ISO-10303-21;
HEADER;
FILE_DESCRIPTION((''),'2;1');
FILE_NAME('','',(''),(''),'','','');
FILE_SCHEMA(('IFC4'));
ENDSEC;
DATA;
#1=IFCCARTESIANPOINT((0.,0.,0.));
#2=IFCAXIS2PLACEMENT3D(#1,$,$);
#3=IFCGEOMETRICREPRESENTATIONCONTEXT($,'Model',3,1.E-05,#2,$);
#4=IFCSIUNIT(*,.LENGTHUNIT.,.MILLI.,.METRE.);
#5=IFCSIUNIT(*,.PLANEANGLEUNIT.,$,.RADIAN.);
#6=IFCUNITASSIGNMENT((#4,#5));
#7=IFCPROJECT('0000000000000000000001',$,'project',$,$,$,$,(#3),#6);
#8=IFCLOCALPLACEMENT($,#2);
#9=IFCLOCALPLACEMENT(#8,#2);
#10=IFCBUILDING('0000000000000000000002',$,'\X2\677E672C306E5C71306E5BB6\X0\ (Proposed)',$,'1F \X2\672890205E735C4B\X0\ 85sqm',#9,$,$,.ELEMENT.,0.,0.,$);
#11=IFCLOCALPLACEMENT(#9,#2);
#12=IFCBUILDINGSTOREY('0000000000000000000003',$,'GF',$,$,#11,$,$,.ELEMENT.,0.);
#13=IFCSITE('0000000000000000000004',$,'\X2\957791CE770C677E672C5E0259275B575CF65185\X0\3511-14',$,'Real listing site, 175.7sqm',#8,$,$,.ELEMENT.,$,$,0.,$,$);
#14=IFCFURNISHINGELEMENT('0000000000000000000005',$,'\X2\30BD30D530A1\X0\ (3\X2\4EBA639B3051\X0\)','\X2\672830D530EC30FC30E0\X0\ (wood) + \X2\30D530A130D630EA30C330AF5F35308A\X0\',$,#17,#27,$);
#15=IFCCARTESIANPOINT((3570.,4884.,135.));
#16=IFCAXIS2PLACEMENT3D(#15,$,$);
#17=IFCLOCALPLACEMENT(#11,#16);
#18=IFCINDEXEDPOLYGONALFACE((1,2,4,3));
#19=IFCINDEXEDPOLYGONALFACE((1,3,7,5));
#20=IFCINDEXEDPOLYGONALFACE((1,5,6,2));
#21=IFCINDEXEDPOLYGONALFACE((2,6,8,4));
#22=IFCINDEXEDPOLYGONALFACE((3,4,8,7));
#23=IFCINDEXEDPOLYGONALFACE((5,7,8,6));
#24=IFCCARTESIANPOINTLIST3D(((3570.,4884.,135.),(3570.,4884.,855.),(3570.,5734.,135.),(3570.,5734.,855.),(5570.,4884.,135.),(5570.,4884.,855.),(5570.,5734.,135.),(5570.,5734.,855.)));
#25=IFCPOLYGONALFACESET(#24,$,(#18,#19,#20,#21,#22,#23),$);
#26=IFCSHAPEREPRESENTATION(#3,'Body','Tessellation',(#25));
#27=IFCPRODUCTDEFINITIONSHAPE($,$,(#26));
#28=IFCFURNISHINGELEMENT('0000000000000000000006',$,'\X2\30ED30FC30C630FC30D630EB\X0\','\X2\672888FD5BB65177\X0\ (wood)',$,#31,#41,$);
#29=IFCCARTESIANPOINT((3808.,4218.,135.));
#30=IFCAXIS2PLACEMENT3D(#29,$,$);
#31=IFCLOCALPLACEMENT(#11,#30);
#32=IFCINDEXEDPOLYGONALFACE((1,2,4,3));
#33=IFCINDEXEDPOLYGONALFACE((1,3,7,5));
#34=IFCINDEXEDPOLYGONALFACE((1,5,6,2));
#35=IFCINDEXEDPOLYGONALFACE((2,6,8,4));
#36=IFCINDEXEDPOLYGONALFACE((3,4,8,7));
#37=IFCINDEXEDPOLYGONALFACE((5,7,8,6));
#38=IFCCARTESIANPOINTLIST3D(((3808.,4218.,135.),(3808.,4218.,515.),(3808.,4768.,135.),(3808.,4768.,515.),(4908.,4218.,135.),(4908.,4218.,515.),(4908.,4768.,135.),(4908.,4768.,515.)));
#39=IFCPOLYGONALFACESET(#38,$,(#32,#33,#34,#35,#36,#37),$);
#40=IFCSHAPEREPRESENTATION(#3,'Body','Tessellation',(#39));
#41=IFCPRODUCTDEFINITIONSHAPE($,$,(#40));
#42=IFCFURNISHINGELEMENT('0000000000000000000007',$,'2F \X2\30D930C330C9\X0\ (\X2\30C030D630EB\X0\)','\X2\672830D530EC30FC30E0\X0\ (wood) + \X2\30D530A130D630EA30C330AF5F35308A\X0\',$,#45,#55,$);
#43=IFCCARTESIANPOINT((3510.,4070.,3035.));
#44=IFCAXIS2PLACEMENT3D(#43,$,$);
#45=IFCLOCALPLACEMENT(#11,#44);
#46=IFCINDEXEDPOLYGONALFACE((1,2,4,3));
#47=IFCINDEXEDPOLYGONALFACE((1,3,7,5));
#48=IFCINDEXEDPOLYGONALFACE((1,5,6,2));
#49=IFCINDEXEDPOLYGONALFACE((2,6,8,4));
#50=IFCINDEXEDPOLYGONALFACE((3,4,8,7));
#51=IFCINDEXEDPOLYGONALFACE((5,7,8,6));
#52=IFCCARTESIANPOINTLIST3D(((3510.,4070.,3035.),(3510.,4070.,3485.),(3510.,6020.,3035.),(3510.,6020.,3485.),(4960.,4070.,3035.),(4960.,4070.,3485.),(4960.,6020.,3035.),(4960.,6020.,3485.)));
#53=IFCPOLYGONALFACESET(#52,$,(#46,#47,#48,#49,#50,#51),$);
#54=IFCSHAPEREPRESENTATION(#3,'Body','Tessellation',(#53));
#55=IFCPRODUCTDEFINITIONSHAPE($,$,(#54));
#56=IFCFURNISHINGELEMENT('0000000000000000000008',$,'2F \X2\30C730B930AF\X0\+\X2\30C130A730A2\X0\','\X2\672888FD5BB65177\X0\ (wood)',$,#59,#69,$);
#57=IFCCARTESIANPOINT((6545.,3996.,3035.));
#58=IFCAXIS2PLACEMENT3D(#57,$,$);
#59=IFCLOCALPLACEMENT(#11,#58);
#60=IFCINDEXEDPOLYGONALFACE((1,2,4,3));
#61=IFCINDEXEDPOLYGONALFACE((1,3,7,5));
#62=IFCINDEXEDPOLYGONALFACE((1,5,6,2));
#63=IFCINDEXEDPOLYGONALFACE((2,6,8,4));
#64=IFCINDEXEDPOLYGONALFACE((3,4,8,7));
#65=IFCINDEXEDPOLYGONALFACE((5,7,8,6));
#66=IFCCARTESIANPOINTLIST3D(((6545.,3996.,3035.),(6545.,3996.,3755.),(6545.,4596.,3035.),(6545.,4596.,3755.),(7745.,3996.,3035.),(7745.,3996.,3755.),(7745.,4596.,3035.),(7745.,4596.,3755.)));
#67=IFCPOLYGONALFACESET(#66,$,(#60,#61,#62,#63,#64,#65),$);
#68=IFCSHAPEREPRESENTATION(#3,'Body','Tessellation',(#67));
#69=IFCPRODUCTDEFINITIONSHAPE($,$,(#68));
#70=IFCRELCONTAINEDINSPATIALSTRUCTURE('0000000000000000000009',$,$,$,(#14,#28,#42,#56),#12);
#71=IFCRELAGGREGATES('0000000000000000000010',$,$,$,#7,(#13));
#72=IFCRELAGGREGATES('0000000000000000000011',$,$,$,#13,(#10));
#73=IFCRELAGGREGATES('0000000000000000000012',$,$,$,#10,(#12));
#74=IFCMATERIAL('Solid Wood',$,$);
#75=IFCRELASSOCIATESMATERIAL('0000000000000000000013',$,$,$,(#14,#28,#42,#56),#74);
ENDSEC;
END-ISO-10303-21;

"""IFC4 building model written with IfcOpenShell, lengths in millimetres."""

from ifc_helpers import new_model, si_unit, frame, frame_2d, origin, place, context, project, spatial, rectangle, extrude, material, element, save


model = new_model("IFC4")

# Units and contexts
model_context = context("Model", 3, precision=1e-05, world=origin())
ifc_project = project(units=[si_unit("LENGTHUNIT", "METRE", prefix="MILLI"), si_unit("PLANEANGLEUNIT", "RADIAN")], contexts=[model_context])

# Site, building, storey
site_placement = place(None, origin())
site = spatial("IfcSite", under=ifc_project, at=site_placement, Name="長野県松本市大字島内3511-14", ObjectType="Real listing site, 175.7sqm", CompositionType="ELEMENT", RefElevation=0.0)
building_placement = place(site_placement, origin())
building = spatial("IfcBuilding", under=site, at=building_placement, Name="松本の山の家 (Proposed)", ObjectType="1F 木造平屋 85sqm", CompositionType="ELEMENT", ElevationOfRefHeight=0.0, ElevationOfTerrain=0.0)
storey_placement = place(building_placement, origin())
storey = spatial("IfcBuildingStorey", under=building, at=storey_placement, Name="GF", CompositionType="ELEMENT", Elevation=0.0)

# Shared definitions
ifc_material_1 = material(Name="Solid Wood")

# Furnishing elements
furnishing_1_placement = place(storey_placement, frame((3570.0, 4884.0, 135.0)))
element("IfcFurnishingElement", 1, at=furnishing_1_placement, inside=storey, material=ifc_material_1, Name="ソファ (3人掛け)", Description="木フレーム (wood) + ファブリック張り", context=model_context, shape_type="SweptSolid", body=[
    extrude(rectangle(XDim=2000.0, YDim=850.0, at=frame_2d((1000.0, 425.0))), frame((3570.0, 4884.0, 135.0)), (0.0, 0.0, 1.0), 720.0),
])
furnishing_2_placement = place(storey_placement, frame((3808.0, 4218.0, 135.0)))
element("IfcFurnishingElement", 2, at=furnishing_2_placement, inside=storey, material=ifc_material_1, Name="ローテーブル", Description="木製家具 (wood)", context=model_context, shape_type="SweptSolid", body=[
    extrude(rectangle(XDim=1100.0, YDim=550.0, at=frame_2d((550.0, 275.0))), frame((3808.0, 4218.0, 135.0)), (0.0, 0.0, 1.0), 380.0),
])
furnishing_3_placement = place(storey_placement, frame((3510.0, 4070.0, 3035.0)))
element("IfcFurnishingElement", 3, at=furnishing_3_placement, inside=storey, material=ifc_material_1, Name="2F ベッド (ダブル)", Description="木フレーム (wood) + ファブリック張り", context=model_context, shape_type="SweptSolid", body=[
    extrude(rectangle(XDim=1450.0, YDim=1950.0, at=frame_2d((725.0, 975.0))), frame((3510.0, 4070.0, 3035.0)), (0.0, 0.0, 1.0), 450.0),
])
furnishing_4_placement = place(storey_placement, frame((6545.0, 3996.0, 3035.0)))
element("IfcFurnishingElement", 4, at=furnishing_4_placement, inside=storey, material=ifc_material_1, Name="2F デスク+チェア", Description="木製家具 (wood)", context=model_context, shape_type="SweptSolid", body=[
    extrude(rectangle(XDim=1200.0, YDim=600.0, at=frame_2d((600.0, 300.0))), frame((6545.0, 3996.0, 3035.0)), (0.0, 0.0, 1.0), 720.0),
])

save(model, "model.ifc")
